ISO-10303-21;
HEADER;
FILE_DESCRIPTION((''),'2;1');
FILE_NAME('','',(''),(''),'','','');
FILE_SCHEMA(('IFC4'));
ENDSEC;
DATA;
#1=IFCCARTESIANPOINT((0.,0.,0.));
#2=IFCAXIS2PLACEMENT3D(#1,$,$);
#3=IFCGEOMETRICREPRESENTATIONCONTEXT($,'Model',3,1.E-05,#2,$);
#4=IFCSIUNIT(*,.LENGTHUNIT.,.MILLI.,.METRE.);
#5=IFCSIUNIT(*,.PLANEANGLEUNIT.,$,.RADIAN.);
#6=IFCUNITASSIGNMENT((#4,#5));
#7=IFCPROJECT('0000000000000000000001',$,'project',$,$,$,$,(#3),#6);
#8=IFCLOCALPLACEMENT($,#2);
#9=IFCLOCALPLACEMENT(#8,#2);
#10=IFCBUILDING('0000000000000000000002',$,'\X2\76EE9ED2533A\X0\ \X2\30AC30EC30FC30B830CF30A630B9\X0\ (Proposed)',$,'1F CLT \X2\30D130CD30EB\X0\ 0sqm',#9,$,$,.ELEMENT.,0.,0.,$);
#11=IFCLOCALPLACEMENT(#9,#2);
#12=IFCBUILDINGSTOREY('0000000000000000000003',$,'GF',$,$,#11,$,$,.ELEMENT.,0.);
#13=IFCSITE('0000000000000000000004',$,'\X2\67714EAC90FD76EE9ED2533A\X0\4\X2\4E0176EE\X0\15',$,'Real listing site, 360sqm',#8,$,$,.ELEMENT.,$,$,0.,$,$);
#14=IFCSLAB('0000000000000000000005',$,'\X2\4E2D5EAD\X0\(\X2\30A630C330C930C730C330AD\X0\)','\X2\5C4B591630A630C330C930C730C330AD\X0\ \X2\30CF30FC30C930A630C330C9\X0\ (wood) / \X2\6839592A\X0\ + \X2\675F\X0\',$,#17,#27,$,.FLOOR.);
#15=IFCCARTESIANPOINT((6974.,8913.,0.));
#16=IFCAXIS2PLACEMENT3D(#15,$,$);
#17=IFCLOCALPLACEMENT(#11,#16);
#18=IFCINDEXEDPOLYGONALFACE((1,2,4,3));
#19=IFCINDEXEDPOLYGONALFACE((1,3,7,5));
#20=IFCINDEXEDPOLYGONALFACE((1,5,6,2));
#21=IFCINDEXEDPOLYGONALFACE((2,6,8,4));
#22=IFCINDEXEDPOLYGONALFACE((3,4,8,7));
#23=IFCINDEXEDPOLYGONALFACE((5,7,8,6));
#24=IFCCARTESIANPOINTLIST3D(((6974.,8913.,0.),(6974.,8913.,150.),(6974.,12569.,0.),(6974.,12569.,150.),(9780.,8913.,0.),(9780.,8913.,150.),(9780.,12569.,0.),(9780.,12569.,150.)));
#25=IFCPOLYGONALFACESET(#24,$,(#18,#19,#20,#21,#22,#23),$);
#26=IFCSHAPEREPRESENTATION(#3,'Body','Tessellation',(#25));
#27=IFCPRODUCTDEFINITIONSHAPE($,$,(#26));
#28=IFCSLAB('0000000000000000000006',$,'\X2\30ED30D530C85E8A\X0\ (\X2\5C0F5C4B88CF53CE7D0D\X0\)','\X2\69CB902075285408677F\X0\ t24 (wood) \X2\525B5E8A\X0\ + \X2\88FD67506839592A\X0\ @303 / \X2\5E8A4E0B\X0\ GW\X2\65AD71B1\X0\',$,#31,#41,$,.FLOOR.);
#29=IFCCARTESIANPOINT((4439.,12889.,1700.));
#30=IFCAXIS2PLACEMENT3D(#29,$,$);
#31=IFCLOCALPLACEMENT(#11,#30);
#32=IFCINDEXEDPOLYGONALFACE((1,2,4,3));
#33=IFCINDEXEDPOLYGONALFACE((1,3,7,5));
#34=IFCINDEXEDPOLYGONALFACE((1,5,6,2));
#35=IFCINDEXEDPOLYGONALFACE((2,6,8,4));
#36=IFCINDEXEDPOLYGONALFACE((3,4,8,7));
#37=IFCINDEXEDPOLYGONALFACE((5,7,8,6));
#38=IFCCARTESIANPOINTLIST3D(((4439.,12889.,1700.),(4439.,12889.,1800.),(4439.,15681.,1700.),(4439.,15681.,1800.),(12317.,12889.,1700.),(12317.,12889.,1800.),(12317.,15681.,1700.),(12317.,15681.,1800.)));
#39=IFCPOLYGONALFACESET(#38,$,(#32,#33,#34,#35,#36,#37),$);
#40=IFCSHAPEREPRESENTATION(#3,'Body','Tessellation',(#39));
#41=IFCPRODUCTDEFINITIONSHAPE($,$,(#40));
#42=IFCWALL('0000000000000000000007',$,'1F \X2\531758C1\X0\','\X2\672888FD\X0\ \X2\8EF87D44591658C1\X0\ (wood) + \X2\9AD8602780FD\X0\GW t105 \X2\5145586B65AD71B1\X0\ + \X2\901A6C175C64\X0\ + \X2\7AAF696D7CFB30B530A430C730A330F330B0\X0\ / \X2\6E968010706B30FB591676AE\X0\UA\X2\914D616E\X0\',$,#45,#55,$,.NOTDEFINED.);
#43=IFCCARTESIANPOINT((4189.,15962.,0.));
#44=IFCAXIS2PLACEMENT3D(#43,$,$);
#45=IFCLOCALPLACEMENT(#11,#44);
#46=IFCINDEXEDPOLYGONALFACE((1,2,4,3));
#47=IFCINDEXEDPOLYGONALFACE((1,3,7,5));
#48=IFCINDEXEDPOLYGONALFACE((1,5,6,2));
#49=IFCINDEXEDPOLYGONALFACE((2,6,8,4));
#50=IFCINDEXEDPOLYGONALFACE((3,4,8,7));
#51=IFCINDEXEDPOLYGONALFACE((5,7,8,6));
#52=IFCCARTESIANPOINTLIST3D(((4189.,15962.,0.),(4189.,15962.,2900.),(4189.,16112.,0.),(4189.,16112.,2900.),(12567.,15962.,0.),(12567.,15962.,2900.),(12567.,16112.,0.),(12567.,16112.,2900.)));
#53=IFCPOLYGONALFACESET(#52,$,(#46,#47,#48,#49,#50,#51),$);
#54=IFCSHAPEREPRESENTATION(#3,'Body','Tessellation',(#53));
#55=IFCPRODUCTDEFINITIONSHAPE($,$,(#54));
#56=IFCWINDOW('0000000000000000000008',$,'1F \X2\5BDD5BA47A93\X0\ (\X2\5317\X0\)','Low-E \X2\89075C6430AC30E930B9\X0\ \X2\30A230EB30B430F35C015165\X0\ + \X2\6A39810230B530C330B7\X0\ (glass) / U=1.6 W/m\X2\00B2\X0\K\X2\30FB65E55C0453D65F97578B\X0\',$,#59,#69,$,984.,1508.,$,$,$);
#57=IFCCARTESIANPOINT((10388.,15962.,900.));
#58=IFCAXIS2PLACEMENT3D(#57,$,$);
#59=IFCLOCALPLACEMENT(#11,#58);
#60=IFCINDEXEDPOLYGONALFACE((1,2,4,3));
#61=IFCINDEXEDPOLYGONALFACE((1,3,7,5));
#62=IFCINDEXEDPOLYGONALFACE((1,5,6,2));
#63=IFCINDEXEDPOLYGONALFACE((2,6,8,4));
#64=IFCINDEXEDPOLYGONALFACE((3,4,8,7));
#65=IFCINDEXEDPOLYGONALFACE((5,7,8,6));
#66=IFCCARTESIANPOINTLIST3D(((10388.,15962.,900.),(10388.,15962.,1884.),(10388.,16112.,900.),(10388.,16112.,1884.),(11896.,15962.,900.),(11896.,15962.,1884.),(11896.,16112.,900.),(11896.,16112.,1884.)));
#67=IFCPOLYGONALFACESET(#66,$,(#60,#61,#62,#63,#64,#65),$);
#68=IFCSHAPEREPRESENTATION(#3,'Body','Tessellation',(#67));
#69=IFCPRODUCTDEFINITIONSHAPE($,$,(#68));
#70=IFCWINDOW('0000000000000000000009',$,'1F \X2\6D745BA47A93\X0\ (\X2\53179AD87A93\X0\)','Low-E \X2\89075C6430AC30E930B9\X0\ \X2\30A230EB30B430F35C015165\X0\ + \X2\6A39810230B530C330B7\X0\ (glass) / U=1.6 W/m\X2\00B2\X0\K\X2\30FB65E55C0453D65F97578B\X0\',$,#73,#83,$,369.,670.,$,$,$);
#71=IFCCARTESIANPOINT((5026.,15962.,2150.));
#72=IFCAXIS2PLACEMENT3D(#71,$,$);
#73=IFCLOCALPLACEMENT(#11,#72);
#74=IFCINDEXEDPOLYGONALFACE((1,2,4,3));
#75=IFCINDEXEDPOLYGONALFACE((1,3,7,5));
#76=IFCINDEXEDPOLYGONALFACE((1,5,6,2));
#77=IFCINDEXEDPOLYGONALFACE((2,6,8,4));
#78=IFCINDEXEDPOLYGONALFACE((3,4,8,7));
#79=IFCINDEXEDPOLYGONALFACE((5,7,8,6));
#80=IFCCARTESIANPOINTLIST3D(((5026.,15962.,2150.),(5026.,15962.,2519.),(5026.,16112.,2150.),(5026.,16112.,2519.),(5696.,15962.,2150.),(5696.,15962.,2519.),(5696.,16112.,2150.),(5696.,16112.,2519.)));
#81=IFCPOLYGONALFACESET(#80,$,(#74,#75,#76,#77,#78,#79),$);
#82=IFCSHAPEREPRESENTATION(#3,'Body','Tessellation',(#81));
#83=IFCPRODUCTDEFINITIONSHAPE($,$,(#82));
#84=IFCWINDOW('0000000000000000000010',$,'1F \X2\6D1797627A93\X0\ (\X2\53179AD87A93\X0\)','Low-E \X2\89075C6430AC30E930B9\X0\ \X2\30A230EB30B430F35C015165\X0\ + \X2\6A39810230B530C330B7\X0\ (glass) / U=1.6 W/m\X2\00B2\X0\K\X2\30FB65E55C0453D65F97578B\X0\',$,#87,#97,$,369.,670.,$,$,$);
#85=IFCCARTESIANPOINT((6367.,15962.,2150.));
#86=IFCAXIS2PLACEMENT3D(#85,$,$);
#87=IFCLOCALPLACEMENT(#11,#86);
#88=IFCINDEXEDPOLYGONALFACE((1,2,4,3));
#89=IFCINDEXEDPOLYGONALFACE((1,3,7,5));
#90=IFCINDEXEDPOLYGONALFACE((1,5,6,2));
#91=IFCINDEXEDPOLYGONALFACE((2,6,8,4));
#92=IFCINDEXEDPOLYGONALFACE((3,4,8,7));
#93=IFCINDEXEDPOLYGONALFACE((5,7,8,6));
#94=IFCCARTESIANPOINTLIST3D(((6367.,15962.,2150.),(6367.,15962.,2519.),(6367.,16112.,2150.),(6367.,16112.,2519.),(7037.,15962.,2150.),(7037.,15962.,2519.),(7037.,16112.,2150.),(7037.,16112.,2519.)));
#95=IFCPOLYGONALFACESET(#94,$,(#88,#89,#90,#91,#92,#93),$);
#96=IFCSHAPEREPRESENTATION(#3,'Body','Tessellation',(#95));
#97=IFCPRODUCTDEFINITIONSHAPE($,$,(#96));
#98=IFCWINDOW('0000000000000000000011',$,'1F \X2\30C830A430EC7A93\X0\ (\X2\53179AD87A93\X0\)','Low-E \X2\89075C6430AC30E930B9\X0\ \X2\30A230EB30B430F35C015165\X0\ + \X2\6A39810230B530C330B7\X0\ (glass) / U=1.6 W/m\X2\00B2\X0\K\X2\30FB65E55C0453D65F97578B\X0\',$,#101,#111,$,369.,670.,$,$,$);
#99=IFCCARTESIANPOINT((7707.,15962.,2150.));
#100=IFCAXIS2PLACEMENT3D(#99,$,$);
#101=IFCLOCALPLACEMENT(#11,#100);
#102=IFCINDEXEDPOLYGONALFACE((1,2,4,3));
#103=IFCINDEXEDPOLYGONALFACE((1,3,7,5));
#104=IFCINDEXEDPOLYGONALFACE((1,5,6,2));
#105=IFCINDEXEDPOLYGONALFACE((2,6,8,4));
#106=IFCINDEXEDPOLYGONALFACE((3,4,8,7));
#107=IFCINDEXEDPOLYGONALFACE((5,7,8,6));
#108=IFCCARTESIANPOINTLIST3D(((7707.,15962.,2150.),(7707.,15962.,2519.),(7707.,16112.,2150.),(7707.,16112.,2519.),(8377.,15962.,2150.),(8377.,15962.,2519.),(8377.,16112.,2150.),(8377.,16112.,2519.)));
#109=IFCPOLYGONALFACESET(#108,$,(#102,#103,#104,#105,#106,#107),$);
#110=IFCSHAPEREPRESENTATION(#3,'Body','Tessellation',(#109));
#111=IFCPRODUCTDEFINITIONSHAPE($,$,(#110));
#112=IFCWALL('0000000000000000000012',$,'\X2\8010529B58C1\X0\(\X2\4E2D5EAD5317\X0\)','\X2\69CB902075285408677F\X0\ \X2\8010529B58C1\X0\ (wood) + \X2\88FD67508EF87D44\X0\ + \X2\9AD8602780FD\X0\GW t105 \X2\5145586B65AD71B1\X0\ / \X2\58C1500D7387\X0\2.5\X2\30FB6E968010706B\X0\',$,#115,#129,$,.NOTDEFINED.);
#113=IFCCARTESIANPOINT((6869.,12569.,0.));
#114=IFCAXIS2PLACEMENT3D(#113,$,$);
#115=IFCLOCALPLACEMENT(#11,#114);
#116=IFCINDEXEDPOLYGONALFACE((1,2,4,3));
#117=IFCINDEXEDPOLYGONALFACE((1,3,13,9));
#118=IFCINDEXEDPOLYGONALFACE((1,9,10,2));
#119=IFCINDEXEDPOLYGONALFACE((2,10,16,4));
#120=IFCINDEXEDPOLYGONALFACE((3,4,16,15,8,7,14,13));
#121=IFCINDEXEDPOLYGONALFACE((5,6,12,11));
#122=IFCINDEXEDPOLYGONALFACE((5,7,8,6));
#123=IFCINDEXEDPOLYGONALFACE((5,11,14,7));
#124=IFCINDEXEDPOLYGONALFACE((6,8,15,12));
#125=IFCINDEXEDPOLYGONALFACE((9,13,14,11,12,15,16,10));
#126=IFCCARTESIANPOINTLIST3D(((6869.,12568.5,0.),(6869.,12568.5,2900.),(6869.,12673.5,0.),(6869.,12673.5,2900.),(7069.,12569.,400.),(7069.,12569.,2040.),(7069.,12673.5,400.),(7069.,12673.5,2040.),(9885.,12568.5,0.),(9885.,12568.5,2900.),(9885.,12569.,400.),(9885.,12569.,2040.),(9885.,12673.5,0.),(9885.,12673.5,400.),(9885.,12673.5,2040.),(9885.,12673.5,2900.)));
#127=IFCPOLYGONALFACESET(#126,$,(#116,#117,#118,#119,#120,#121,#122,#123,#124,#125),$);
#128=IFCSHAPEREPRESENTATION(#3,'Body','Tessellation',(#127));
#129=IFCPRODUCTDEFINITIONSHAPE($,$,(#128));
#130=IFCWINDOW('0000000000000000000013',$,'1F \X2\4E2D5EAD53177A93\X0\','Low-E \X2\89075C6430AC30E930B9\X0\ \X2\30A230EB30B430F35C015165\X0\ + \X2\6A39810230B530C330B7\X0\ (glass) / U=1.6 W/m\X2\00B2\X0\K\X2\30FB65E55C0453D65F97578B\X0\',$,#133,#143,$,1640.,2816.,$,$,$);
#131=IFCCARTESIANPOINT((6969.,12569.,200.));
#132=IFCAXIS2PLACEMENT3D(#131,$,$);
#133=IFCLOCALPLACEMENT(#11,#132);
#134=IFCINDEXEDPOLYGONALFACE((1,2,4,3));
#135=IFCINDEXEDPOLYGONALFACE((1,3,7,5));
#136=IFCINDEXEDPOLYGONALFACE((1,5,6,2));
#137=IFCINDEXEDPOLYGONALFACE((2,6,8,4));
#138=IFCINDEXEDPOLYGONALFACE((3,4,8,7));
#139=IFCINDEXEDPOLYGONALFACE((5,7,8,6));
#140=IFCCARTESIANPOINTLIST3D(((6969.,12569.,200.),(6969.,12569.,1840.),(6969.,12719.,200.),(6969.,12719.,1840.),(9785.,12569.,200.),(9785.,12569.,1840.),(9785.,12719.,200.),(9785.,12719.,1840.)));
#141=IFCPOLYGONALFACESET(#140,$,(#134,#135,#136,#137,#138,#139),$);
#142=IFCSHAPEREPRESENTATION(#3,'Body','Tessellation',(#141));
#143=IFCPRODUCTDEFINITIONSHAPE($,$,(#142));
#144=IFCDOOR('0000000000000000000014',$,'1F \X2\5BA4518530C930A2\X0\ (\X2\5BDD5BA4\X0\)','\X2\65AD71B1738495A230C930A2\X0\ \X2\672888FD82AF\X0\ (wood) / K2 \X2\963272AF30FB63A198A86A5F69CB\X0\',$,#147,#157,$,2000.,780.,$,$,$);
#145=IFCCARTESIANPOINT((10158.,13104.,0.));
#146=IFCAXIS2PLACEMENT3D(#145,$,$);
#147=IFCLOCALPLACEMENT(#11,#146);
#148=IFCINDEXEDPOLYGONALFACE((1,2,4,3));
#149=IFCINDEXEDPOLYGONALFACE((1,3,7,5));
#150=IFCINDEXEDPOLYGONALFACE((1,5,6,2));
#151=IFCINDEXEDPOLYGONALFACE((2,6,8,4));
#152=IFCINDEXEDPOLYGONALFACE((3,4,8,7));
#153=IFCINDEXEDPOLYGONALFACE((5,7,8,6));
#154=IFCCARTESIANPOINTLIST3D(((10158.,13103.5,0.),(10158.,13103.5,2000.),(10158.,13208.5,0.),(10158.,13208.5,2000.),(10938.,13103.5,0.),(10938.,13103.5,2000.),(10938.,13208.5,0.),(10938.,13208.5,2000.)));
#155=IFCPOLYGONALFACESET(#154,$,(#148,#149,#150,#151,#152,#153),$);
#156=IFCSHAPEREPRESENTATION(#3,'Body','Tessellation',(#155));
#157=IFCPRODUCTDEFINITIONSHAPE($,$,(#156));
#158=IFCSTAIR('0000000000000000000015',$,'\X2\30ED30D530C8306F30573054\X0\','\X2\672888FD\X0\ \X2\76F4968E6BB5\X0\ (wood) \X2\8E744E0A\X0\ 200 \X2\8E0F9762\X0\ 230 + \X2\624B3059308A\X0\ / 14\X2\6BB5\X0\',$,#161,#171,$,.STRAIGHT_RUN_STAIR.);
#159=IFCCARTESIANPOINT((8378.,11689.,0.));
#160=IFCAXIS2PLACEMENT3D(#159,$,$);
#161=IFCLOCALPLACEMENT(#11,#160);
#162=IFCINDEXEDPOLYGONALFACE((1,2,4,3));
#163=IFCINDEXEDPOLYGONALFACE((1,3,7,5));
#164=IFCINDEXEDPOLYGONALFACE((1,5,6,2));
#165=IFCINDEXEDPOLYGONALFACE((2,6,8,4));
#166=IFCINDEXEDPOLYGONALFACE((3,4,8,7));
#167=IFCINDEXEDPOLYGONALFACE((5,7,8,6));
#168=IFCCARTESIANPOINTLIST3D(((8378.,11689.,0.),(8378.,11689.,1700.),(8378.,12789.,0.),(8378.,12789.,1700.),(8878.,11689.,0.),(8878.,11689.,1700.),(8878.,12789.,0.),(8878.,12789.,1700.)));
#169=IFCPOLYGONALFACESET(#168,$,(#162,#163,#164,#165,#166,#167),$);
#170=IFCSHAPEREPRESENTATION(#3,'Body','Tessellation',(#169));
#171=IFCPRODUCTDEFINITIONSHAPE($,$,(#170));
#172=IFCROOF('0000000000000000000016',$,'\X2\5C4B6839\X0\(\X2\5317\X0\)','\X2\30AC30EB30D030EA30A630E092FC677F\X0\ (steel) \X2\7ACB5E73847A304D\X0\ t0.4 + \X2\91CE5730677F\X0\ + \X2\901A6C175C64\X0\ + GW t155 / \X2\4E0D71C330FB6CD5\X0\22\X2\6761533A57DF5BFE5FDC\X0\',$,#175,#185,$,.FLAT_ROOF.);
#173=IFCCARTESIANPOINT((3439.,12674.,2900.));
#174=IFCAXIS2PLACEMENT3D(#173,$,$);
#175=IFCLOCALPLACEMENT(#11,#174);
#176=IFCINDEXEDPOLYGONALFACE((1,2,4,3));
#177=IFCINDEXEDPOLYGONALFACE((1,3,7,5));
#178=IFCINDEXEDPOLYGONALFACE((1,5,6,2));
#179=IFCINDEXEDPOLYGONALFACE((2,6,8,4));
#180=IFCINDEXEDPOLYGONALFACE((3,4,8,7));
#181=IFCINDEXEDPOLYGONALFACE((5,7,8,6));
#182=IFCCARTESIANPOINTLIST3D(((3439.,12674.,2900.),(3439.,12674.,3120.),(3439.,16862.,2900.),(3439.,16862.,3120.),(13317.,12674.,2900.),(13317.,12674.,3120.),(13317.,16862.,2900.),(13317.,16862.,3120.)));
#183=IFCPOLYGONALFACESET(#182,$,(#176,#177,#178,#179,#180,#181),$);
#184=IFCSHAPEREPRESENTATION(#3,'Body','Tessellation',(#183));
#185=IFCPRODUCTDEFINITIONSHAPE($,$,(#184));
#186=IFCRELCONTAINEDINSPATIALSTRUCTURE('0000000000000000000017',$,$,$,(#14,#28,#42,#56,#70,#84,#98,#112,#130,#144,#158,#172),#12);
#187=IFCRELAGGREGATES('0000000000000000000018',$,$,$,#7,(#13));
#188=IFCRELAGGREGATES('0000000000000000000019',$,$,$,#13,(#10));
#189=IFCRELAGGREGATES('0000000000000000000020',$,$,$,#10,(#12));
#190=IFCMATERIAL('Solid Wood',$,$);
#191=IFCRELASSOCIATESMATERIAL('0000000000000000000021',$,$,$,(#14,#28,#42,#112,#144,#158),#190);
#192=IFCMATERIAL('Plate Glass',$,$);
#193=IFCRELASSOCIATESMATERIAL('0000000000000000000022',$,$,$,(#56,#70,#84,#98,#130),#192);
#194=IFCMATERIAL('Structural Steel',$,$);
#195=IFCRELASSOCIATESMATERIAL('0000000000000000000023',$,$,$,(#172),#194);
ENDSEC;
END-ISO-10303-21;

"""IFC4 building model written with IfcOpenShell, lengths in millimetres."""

from ifc_helpers import new_model, si_unit, frame, frame_2d, origin, place, context, project, spatial, rectangle, extrude, material, element, fill, save


model = new_model("IFC4")

# Units and contexts
model_context = context("Model", 3, precision=1e-05, world=origin())
ifc_project = project(units=[si_unit("LENGTHUNIT", "METRE", prefix="MILLI"), si_unit("PLANEANGLEUNIT", "RADIAN")], contexts=[model_context])

# Site, building, storey
site_placement = place(None, origin())
site = spatial("IfcSite", under=ifc_project, at=site_placement, Name="東京都目黒区4丁目15", ObjectType="Real listing site, 360sqm", CompositionType="ELEMENT", RefElevation=0.0)
building_placement = place(site_placement, origin())
building = spatial("IfcBuilding", under=site, at=building_placement, Name="目黒区 ガレージハウス (Proposed)", ObjectType="1F CLT パネル 0sqm", CompositionType="ELEMENT", ElevationOfRefHeight=0.0, ElevationOfTerrain=0.0)
storey_placement = place(building_placement, origin())
storey = spatial("IfcBuildingStorey", under=building, at=storey_placement, Name="GF", CompositionType="ELEMENT", Elevation=0.0)

# Slabs
ifc_material_1 = material(Name="Solid Wood")
slab_1_placement = place(storey_placement, frame((6974.0, 8913.0, 0.0)))
element("IfcSlab", 1, at=slab_1_placement, inside=storey, material=ifc_material_1, Name="中庭(ウッドデッキ)", Description="屋外ウッドデッキ ハードウッド (wood) / 根太 + 束", PredefinedType="FLOOR", context=model_context, shape_type="SweptSolid", body=[
    extrude(rectangle(XDim=2806.0, YDim=3656.0, at=frame_2d((1403.0, 1828.0))), frame((6974.0, 8913.0, 0.0)), (0.0, 0.0, 1.0), 150.0),
])
slab_2_placement = place(storey_placement, frame((4439.0, 12889.0, 1700.0)))
element("IfcSlab", 2, at=slab_2_placement, inside=storey, material=ifc_material_1, Name="ロフト床 (小屋裏収納)", Description="構造用合板 t24 (wood) 剛床 + 製材根太 @303 / 床下 GW断熱", PredefinedType="FLOOR", context=model_context, shape_type="SweptSolid", body=[
    extrude(rectangle(XDim=7878.0, YDim=2792.0, at=frame_2d((3939.0, 1396.0))), frame((4439.0, 12889.0, 1700.0)), (0.0, 0.0, 1.0), 100.0),
])

# Wall, openings, windows
wall_1_placement = place(storey_placement, frame((4189.0, 15962.0, 0.0)))
wall_1 = element("IfcWall", 3, at=wall_1_placement, inside=storey, material=ifc_material_1, Name="1F 北壁", Description="木製 軸組外壁 (wood) + 高性能GW t105 充填断熱 + 通気層 + 窯業系サイディング / 準耐火・外皮UA配慮", PredefinedType="NOTDEFINED", context=model_context, shape_type="SweptSolid", body=[
    extrude(rectangle(XDim=8378.0, YDim=150.0, at=frame_2d((4189.0, 75.0))), frame((4189.0, 15962.0, 0.0)), (0.0, 0.0, 1.0), 2900.0),
])
opening_1_placement = place(storey_placement, frame((10388.0, 15962.0, 900.0)))
opening_1 = element("IfcOpeningElement", 4, at=opening_1_placement, cuts=wall_1, PredefinedType="NOTDEFINED", context=model_context, shape_type="SweptSolid", body=[
    extrude(rectangle(XDim=1508.0, YDim=150.0, at=frame_2d((754.0, 75.0))), frame((10388.0, 15962.0, 900.0)), (0.0, 0.0, 1.0), 984.0),
])
opening_2_placement = place(storey_placement, frame((5026.0, 15962.0, 2150.0)))
opening_2 = element("IfcOpeningElement", 5, at=opening_2_placement, cuts=wall_1, PredefinedType="NOTDEFINED", context=model_context, shape_type="SweptSolid", body=[
    extrude(rectangle(XDim=670.0, YDim=150.0, at=frame_2d((335.0, 75.0))), frame((5026.0, 15962.0, 2150.0)), (0.0, 0.0, 1.0), 369.0),
])
opening_3_placement = place(storey_placement, frame((6367.0, 15962.0, 2150.0)))
opening_3 = element("IfcOpeningElement", 6, at=opening_3_placement, cuts=wall_1, PredefinedType="NOTDEFINED", context=model_context, shape_type="SweptSolid", body=[
    extrude(rectangle(XDim=670.0, YDim=150.0, at=frame_2d((335.0, 75.0))), frame((6367.0, 15962.0, 2150.0)), (0.0, 0.0, 1.0), 369.0),
])
opening_4_placement = place(storey_placement, frame((7707.0, 15962.0, 2150.0)))
opening_4 = element("IfcOpeningElement", 7, at=opening_4_placement, cuts=wall_1, PredefinedType="NOTDEFINED", context=model_context, shape_type="SweptSolid", body=[
    extrude(rectangle(XDim=670.0, YDim=150.0, at=frame_2d((335.0, 75.0))), frame((7707.0, 15962.0, 2150.0)), (0.0, 0.0, 1.0), 369.0),
])
ifc_material_2 = material(Name="Plate Glass")
window_1_placement = place(storey_placement, frame((10388.0, 15962.0, 900.0)))
window_1 = element("IfcWindow", 8, at=window_1_placement, inside=storey, material=ifc_material_2, Name="1F 寝室窓 (北)", Description="Low-E 複層ガラス アルゴン封入 + 樹脂サッシ (glass) / U=1.6 W/m²K・日射取得型", OverallHeight=984.0, OverallWidth=1508.0, context=model_context, shape_type="SweptSolid", body=[
    extrude(rectangle(XDim=1508.0, YDim=150.0, at=frame_2d((754.0, 75.0))), frame((10388.0, 15962.0, 900.0)), (0.0, 0.0, 1.0), 984.0),
])
fill(opening_1, window_1)
window_2_placement = place(storey_placement, frame((5026.0, 15962.0, 2150.0)))
window_2 = element("IfcWindow", 9, at=window_2_placement, inside=storey, material=ifc_material_2, Name="1F 浴室窓 (北高窓)", Description="Low-E 複層ガラス アルゴン封入 + 樹脂サッシ (glass) / U=1.6 W/m²K・日射取得型", OverallHeight=369.0, OverallWidth=670.0, context=model_context, shape_type="SweptSolid", body=[
    extrude(rectangle(XDim=670.0, YDim=150.0, at=frame_2d((335.0, 75.0))), frame((5026.0, 15962.0, 2150.0)), (0.0, 0.0, 1.0), 369.0),
])
fill(opening_2, window_2)
window_3_placement = place(storey_placement, frame((6367.0, 15962.0, 2150.0)))
window_3 = element("IfcWindow", 10, at=window_3_placement, inside=storey, material=ifc_material_2, Name="1F 洗面窓 (北高窓)", Description="Low-E 複層ガラス アルゴン封入 + 樹脂サッシ (glass) / U=1.6 W/m²K・日射取得型", OverallHeight=369.0, OverallWidth=670.0, context=model_context, shape_type="SweptSolid", body=[
    extrude(rectangle(XDim=670.0, YDim=150.0, at=frame_2d((335.0, 75.0))), frame((6367.0, 15962.0, 2150.0)), (0.0, 0.0, 1.0), 369.0),
])
fill(opening_3, window_3)
window_4_placement = place(storey_placement, frame((7707.0, 15962.0, 2150.0)))
window_4 = element("IfcWindow", 11, at=window_4_placement, inside=storey, material=ifc_material_2, Name="1F トイレ窓 (北高窓)", Description="Low-E 複層ガラス アルゴン封入 + 樹脂サッシ (glass) / U=1.6 W/m²K・日射取得型", OverallHeight=369.0, OverallWidth=670.0, context=model_context, shape_type="SweptSolid", body=[
    extrude(rectangle(XDim=670.0, YDim=150.0, at=frame_2d((335.0, 75.0))), frame((7707.0, 15962.0, 2150.0)), (0.0, 0.0, 1.0), 369.0),
])
fill(opening_4, window_4)

# Wall, opening, window
wall_2_placement = place(storey_placement, frame((6869.0, 12569.0, 0.0)))
wall_2 = element("IfcWall", 12, at=wall_2_placement, inside=storey, material=ifc_material_1, Name="耐力壁(中庭北)", Description="構造用合板 耐力壁 (wood) + 製材軸組 + 高性能GW t105 充填断熱 / 壁倍率2.5・準耐火", PredefinedType="NOTDEFINED", context=model_context, shape_type="SweptSolid", body=[
    extrude(rectangle(XDim=3016.0, YDim=105.0, at=frame_2d((1508.0, 52.0))), frame((6869.0, 12569.0, 0.0)), (0.0, 0.0, 1.0), 2900.0),
])
opening_5_placement = place(storey_placement, frame((6969.0, 12569.0, 200.0)))
opening_5 = element("IfcOpeningElement", 13, at=opening_5_placement, cuts=wall_2, PredefinedType="NOTDEFINED", context=model_context, shape_type="SweptSolid", body=[
    extrude(rectangle(XDim=2816.0, YDim=150.0, at=frame_2d((1408.0, 75.0))), frame((6969.0, 12569.0, 200.0)), (0.0, 0.0, 1.0), 1640.0),
])
window_5_placement = place(storey_placement, frame((6969.0, 12569.0, 200.0)))
window_5 = element("IfcWindow", 14, at=window_5_placement, inside=storey, material=ifc_material_2, Name="1F 中庭北窓", Description="Low-E 複層ガラス アルゴン封入 + 樹脂サッシ (glass) / U=1.6 W/m²K・日射取得型", OverallHeight=1640.0, OverallWidth=2816.0, context=model_context, shape_type="SweptSolid", body=[
    extrude(rectangle(XDim=2816.0, YDim=150.0, at=frame_2d((1408.0, 75.0))), frame((6969.0, 12569.0, 200.0)), (0.0, 0.0, 1.0), 1640.0),
])
fill(opening_5, window_5)

# Door
door_1_placement = place(storey_placement, frame((10158.0, 13104.0, 0.0)))
element("IfcDoor", 15, at=door_1_placement, inside=storey, material=ifc_material_1, Name="1F 室内ドア (寝室)", Description="断熱玄関ドア 木製芯 (wood) / K2 防犯・採風機構", OverallHeight=2000.0, OverallWidth=780.0, context=model_context, shape_type="SweptSolid", body=[
    extrude(rectangle(XDim=780.0, YDim=105.0, at=frame_2d((390.0, 52.0))), frame((10158.0, 13104.0, 0.0)), (0.0, 0.0, 1.0), 2000.0),
])

# Stair
stair_placement = place(storey_placement, frame((8378.0, 11689.0, 0.0)))
element("IfcStair", 16, at=stair_placement, inside=storey, material=ifc_material_1, Name="ロフトはしご", Description="木製 直階段 (wood) 蹴上 200 踏面 230 + 手すり / 14段", PredefinedType="STRAIGHT_RUN_STAIR", context=model_context, shape_type="SweptSolid", body=[
    extrude(rectangle(XDim=500.0, YDim=1100.0, at=frame_2d((250.0, 550.0))), frame((8378.0, 11689.0, 0.0)), (0.0, 0.0, 1.0), 1700.0),
])

# Roof
ifc_material_3 = material(Name="Structural Steel")
roof_1_placement = place(storey_placement, frame((3439.0, 12674.0, 2900.0)))
element("IfcRoof", 17, at=roof_1_placement, inside=storey, material=ifc_material_3, Name="屋根(北)", Description="ガルバリウム鋼板 (steel) 立平葺き t0.4 + 野地板 + 通気層 + GW t155 / 不燃・法22条区域対応", PredefinedType="FLAT_ROOF", context=model_context, shape_type="SweptSolid", body=[
    extrude(rectangle(XDim=9878.0, YDim=4188.0, at=frame_2d((4939.0, 2094.0))), frame((3439.0, 12674.0, 2900.0)), (0.0, 0.0, 1.0), 220.0),
])

save(model, "model.ifc")
